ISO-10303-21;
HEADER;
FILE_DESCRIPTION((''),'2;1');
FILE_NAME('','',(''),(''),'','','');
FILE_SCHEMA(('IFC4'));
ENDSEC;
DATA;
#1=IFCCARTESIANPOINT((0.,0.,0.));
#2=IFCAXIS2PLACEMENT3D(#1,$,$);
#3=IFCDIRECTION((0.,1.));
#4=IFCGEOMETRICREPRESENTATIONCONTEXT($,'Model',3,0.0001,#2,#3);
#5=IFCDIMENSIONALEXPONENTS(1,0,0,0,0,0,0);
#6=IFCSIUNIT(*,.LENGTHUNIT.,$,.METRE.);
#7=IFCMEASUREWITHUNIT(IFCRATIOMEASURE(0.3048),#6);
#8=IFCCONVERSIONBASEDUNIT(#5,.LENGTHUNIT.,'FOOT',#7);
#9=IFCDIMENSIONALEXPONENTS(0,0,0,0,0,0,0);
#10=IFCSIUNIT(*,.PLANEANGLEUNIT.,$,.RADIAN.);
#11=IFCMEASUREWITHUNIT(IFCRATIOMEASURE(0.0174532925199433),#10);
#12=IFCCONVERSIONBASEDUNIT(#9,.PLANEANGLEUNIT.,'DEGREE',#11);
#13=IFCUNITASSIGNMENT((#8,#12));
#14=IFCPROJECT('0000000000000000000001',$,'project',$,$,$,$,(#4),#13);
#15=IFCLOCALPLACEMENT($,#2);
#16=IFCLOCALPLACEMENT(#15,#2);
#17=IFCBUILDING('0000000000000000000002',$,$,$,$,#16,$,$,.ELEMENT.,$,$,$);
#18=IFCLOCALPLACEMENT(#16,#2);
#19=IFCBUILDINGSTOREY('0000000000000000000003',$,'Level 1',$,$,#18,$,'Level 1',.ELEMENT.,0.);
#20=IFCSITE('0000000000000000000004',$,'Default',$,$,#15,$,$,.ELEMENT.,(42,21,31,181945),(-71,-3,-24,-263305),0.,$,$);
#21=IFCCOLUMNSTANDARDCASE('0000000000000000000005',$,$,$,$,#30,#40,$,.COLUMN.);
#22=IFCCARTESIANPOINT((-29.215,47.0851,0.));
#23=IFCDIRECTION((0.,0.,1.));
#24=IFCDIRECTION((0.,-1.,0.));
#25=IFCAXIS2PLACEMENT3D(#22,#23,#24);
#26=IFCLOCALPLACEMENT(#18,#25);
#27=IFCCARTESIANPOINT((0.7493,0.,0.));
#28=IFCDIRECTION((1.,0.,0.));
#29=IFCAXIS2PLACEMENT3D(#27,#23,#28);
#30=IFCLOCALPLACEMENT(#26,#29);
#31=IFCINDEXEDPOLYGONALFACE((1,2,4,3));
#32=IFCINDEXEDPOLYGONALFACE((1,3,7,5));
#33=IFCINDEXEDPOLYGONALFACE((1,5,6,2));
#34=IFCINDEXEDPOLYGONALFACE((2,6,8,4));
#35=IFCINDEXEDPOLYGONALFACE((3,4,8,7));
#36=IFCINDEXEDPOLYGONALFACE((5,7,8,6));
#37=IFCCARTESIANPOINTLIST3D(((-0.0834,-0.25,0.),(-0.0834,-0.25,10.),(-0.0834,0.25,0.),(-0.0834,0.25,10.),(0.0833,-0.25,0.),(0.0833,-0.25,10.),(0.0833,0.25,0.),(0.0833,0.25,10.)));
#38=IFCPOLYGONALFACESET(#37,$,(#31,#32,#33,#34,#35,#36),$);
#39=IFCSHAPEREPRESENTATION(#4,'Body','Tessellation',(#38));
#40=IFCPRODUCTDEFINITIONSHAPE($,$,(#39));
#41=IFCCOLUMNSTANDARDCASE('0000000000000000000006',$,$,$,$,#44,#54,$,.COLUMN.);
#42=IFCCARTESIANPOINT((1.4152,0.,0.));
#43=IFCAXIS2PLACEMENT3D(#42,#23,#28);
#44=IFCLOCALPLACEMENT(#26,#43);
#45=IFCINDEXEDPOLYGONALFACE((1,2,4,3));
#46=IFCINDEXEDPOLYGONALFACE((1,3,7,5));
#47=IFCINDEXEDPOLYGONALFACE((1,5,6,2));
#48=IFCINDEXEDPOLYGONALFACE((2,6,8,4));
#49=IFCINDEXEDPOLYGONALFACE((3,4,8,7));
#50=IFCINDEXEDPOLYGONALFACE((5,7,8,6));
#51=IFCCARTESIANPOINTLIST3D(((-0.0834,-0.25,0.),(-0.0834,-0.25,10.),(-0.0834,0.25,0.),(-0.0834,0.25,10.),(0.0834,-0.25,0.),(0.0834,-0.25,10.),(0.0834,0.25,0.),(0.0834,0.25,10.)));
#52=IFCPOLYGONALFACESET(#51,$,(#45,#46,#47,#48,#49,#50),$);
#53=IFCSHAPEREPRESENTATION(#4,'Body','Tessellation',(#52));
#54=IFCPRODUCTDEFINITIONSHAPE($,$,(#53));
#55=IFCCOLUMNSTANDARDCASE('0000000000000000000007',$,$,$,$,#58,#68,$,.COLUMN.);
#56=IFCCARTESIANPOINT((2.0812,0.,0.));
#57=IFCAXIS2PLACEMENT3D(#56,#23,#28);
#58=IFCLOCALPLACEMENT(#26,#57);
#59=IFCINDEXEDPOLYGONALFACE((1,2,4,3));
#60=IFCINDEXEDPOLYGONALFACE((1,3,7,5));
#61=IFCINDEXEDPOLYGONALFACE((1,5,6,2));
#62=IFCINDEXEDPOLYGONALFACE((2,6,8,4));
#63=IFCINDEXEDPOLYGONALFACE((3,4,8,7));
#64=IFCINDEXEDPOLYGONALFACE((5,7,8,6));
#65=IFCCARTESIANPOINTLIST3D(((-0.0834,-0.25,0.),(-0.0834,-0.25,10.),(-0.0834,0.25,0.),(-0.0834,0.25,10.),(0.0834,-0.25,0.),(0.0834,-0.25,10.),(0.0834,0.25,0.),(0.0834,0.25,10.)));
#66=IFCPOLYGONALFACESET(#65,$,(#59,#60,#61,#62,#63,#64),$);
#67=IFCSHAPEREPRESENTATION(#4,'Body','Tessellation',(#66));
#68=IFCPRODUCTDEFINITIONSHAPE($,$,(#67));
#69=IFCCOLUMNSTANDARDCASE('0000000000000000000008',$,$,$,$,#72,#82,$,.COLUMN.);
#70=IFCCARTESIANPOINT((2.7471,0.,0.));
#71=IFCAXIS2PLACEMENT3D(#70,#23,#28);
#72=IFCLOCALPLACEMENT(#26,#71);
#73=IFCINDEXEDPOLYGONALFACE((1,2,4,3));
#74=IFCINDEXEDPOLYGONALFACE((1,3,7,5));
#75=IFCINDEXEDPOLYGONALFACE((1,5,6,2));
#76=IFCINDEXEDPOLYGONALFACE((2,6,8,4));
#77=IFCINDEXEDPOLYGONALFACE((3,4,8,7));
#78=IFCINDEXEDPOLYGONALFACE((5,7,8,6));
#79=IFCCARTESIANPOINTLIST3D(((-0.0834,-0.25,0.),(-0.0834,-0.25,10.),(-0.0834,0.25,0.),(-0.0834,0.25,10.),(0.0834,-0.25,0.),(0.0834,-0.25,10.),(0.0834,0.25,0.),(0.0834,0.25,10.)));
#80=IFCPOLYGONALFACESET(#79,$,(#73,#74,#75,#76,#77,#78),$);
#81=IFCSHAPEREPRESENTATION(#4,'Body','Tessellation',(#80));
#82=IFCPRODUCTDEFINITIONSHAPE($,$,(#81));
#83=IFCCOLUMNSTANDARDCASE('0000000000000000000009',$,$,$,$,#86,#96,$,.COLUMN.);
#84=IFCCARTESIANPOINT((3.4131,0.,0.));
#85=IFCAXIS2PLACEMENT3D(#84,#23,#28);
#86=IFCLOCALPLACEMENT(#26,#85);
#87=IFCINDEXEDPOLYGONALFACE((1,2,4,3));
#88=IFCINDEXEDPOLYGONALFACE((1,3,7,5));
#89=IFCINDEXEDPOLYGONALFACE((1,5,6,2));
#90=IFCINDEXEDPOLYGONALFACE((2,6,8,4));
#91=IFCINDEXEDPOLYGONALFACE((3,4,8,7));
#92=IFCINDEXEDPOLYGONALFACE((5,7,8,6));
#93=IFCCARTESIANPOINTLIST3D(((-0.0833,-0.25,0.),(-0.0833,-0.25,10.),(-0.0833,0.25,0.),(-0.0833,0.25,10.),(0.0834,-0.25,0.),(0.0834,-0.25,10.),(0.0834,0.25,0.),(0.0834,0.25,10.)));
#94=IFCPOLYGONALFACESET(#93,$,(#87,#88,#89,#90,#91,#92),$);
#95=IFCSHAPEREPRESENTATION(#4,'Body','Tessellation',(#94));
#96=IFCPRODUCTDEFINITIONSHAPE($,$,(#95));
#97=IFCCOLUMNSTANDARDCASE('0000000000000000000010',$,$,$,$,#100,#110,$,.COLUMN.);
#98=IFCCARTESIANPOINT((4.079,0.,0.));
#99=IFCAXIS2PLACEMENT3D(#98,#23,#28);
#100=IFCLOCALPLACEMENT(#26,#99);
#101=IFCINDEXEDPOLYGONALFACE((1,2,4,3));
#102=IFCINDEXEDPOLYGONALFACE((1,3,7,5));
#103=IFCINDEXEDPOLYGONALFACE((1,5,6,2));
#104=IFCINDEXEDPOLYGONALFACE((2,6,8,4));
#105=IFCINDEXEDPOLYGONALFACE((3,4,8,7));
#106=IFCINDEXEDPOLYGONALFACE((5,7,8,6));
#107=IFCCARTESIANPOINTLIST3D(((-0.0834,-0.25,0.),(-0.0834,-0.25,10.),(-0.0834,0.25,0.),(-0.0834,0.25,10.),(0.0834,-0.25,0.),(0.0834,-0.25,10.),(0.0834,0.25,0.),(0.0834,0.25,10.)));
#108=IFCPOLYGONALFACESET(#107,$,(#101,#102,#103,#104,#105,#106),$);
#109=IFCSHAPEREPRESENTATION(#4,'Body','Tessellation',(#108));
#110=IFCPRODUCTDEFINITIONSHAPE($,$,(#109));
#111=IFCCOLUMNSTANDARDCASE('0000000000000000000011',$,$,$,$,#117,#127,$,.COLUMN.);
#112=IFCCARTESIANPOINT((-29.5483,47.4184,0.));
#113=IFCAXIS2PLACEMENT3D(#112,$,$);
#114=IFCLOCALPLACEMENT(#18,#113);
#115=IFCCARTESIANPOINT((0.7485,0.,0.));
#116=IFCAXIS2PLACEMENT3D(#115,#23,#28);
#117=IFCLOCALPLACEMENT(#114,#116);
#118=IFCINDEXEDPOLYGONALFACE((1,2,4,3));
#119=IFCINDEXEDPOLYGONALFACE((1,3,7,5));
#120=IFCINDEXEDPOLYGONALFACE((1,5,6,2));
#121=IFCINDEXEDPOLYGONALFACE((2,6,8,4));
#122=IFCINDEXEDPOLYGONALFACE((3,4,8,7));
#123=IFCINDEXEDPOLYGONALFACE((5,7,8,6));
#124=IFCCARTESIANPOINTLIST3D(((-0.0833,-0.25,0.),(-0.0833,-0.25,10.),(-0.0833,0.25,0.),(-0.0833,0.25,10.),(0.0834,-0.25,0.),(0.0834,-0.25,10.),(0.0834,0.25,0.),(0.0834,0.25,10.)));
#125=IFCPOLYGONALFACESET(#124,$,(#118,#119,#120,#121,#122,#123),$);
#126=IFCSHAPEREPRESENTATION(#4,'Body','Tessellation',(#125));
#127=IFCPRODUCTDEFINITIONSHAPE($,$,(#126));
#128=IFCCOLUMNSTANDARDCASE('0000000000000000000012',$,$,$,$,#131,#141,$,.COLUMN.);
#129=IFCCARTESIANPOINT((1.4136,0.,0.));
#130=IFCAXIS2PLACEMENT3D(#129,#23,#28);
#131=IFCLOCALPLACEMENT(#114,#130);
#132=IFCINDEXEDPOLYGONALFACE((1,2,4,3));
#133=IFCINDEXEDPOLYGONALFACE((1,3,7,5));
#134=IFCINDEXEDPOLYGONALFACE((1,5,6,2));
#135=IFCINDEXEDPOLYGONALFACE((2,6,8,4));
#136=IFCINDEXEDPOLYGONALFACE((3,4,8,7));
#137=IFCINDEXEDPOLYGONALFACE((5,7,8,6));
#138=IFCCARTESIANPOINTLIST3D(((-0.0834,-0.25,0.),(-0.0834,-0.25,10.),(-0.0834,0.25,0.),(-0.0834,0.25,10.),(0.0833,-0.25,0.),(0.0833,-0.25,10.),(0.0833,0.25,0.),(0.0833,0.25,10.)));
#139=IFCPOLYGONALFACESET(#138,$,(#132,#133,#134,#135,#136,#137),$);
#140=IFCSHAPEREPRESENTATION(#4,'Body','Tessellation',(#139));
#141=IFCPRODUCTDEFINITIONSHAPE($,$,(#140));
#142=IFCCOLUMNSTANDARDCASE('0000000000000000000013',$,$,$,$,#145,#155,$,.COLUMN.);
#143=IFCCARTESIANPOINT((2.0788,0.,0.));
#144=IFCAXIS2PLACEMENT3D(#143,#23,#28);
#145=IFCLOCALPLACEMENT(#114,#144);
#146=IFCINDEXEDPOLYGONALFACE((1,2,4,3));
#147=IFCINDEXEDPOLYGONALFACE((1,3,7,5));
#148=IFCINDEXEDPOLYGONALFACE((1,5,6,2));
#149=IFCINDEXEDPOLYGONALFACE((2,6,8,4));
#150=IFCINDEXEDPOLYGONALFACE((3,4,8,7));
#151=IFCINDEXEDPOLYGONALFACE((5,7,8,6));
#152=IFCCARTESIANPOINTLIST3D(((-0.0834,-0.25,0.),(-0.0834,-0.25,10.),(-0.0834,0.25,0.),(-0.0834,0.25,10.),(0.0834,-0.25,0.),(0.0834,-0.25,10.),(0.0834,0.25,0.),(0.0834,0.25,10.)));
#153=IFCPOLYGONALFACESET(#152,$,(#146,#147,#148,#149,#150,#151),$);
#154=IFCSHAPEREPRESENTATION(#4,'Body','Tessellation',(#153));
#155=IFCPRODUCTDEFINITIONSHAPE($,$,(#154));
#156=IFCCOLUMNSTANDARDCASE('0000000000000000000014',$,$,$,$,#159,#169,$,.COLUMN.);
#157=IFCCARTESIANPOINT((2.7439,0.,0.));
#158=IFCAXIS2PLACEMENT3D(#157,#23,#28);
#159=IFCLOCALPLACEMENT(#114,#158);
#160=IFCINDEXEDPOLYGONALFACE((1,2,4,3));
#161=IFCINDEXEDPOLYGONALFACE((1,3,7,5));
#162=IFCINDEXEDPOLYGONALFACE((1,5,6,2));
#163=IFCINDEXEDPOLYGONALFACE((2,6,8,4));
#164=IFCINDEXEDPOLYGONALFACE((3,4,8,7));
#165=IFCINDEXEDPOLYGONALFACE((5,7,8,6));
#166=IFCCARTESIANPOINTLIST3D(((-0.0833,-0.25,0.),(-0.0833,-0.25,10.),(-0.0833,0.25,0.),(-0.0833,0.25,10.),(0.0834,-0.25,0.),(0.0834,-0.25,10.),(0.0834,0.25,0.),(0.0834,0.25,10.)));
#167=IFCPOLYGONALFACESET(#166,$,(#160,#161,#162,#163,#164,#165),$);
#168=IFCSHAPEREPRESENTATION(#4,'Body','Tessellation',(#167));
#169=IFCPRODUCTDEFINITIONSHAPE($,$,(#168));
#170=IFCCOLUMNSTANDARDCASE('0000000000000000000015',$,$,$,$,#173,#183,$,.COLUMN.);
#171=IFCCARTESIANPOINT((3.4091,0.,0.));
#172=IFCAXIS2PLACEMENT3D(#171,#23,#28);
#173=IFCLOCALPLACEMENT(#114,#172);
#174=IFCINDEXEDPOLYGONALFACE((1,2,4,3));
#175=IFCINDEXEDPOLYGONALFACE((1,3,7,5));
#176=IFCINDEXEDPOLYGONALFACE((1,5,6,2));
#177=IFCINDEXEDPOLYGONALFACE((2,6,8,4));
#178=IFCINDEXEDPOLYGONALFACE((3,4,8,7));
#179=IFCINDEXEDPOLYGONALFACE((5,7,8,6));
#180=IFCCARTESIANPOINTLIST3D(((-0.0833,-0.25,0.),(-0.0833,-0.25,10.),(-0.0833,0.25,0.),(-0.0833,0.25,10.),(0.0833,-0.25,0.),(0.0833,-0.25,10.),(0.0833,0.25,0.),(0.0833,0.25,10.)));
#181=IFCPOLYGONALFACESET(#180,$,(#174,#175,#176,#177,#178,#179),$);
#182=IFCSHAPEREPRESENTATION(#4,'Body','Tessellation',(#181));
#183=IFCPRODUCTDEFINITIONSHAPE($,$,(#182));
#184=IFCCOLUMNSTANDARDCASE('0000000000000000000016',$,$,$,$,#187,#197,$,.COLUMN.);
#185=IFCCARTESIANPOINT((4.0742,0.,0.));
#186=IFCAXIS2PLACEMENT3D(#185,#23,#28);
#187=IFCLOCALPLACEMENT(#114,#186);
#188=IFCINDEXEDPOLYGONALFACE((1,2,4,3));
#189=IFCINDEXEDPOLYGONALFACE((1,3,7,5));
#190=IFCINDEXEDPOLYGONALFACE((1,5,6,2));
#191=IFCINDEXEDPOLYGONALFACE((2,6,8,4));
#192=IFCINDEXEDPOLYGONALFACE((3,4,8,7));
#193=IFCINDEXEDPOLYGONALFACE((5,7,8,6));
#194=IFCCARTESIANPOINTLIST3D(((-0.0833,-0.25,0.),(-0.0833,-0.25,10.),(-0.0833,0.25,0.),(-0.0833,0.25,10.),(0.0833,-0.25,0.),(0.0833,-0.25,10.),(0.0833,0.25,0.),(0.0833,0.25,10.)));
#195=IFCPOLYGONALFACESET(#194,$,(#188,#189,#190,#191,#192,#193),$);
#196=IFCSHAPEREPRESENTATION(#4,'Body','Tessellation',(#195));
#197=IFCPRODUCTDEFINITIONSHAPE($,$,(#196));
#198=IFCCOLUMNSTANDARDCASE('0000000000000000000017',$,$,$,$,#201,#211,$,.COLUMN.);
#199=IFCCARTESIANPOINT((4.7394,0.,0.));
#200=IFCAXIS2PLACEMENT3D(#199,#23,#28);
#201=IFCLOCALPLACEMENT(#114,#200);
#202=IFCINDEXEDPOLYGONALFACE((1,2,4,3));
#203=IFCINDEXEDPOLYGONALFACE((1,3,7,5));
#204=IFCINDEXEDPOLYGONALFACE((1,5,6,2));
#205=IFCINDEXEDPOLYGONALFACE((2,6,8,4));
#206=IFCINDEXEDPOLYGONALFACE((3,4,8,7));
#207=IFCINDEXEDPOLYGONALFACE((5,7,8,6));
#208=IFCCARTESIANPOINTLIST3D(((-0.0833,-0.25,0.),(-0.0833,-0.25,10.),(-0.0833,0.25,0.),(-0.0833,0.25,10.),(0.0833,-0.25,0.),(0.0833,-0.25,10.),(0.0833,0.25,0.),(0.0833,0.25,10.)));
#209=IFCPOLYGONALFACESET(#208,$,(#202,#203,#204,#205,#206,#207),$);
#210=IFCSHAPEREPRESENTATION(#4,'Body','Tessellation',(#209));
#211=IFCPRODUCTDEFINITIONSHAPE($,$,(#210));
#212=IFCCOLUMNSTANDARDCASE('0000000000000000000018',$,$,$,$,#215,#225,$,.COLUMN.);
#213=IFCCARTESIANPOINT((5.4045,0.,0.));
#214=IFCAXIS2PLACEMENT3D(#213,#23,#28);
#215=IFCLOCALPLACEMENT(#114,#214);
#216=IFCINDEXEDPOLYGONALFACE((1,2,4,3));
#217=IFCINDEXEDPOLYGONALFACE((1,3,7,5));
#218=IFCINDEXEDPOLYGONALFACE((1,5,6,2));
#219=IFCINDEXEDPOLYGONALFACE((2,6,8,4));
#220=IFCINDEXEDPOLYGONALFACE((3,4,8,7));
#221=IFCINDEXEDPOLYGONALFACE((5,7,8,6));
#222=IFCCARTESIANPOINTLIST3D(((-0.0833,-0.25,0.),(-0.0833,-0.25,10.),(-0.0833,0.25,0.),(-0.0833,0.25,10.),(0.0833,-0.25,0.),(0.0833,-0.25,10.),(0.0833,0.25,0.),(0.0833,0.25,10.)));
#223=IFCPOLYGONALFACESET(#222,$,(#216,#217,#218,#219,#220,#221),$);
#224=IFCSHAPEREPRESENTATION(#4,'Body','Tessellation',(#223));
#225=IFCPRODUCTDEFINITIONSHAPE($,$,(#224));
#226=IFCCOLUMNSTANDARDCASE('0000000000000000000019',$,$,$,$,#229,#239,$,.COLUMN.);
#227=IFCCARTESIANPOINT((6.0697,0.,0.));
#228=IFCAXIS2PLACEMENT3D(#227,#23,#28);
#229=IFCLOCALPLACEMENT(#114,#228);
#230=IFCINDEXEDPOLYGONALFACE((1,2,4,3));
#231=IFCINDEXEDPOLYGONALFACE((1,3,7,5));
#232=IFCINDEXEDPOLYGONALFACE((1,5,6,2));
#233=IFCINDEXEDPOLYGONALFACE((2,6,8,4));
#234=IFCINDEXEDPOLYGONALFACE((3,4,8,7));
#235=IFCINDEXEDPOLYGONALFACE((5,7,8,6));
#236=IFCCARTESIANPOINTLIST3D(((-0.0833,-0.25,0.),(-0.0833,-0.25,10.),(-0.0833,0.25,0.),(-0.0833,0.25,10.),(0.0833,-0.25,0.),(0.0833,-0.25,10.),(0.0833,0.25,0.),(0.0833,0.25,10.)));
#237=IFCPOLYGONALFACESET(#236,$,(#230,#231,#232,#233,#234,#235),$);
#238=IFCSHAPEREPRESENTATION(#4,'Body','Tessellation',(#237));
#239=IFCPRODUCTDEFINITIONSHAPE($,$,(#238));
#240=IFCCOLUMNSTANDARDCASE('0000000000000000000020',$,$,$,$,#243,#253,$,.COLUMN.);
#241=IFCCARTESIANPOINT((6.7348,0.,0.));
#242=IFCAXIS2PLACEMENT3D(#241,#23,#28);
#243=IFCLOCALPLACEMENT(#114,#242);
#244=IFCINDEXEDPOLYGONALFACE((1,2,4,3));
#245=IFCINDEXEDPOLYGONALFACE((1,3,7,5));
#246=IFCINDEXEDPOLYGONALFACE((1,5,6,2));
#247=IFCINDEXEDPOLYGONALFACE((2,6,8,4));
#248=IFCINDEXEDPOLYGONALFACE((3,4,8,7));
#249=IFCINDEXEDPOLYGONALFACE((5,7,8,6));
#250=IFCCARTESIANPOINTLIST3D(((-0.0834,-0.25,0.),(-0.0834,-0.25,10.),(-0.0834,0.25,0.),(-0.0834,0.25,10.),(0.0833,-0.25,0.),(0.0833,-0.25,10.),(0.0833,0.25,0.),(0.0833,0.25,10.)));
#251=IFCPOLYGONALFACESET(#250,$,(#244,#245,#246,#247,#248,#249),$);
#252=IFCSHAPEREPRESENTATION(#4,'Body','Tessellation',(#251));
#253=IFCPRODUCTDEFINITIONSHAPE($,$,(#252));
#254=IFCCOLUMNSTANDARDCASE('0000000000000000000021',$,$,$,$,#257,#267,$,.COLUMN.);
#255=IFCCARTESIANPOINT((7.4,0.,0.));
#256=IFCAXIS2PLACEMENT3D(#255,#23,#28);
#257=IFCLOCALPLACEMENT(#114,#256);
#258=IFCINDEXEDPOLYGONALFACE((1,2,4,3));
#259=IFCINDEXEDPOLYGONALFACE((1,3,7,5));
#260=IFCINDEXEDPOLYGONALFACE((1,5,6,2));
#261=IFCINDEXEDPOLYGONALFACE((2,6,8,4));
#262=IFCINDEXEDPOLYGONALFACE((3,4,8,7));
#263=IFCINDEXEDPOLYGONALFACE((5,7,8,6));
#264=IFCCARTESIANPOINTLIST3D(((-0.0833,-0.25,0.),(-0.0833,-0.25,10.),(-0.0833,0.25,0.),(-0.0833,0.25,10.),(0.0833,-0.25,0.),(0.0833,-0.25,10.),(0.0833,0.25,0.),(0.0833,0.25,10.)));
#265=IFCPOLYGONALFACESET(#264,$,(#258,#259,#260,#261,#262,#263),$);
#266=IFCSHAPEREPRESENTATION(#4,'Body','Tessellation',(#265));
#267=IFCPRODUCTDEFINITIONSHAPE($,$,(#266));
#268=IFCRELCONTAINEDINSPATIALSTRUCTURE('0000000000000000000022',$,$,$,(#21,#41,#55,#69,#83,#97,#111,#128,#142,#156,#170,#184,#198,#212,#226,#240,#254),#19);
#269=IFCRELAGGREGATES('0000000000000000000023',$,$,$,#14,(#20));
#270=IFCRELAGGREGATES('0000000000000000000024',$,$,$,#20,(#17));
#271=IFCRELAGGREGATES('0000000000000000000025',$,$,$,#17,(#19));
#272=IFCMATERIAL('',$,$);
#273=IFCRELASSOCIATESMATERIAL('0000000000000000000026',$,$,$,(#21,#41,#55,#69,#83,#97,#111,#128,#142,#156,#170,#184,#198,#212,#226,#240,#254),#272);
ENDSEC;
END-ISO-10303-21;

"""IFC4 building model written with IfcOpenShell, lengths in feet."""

from ifc_helpers import new_model, entity, si_unit, converted_unit, direction, frame, origin, place, context, project, spatial, rectangle, extrude, material, element, save


model = new_model("IFC4")

# Units and contexts
model_context = context("Model", 3, precision=0.0001, world=origin(), true_north=direction((0.0, 1.0)))
ifc_project = project(units=[converted_unit("LENGTHUNIT", "FOOT", entity("IfcRatioMeasure", 0.3048), si_unit("LENGTHUNIT", "METRE"), dimensions=[1, 0, 0, 0, 0, 0, 0]), converted_unit("PLANEANGLEUNIT", "DEGREE", entity("IfcRatioMeasure", 0.0174532925199433), si_unit("PLANEANGLEUNIT", "RADIAN"), dimensions=[0, 0, 0, 0, 0, 0, 0])], contexts=[model_context])

# Site, building, storey
site_placement = place(None, origin())
site = spatial("IfcSite", under=ifc_project, at=site_placement, Name="Default", CompositionType="ELEMENT", RefLatitude=(42, 21, 31, 181945), RefLongitude=(-71, -3, -24, -263305), RefElevation=0.0)
building_placement = place(site_placement, origin())
building = spatial("IfcBuilding", under=site, at=building_placement, CompositionType="ELEMENT")
storey_placement = place(building_placement, origin())
storey = spatial("IfcBuildingStorey", under=building, at=storey_placement, Name="Level 1", LongName="Level 1", CompositionType="ELEMENT", Elevation=0.0)

# Columns
ifc_material_1 = material(Name="")
wall_1_placement = place(storey_placement, frame((-29.215, 47.0851, 0.0), z_axis=(0.0, 0.0, 1.0), x_axis=(0.0, -1.0, 0.0)))
for number, where, z_axis, x_axis in (
    (1, (0.7493, 0.0, 0.0), (0.0, 0.0, 1.0), (1.0, 0.0, 0.0)),
    (2, (1.4152, 0.0, 0.0), (0.0, 0.0, 1.0), (1.0, 0.0, 0.0)),
    (3, (2.0812, 0.0, 0.0), (0.0, 0.0, 1.0), (1.0, 0.0, 0.0)),
    (4, (2.7471, 0.0, 0.0), (0.0, 0.0, 1.0), (1.0, 0.0, 0.0)),
    (5, (3.4131, 0.0, 0.0), (0.0, 0.0, 1.0), (1.0, 0.0, 0.0)),
    (6, (4.079, 0.0, 0.0), (0.0, 0.0, 1.0), (1.0, 0.0, 0.0)),
):
    element("IfcColumnStandardCase", number, at=place(wall_1_placement, frame(where, z_axis=z_axis, x_axis=x_axis)), inside=storey, material=ifc_material_1, PredefinedType="COLUMN", context=model_context, shape_type="SweptSolid", body=[
        extrude(rectangle(XDim=0.1667, YDim=0.5), origin(), (0.0, 0.0, 1.0), 10.0),
    ])
wall_2_placement = place(storey_placement, frame((-29.5483, 47.4184, 0.0)))
for number, where, z_axis, x_axis in (
    (7, (0.7485, 0.0, 0.0), (0.0, 0.0, 1.0), (1.0, 0.0, 0.0)),
    (8, (1.4136, 0.0, 0.0), (0.0, 0.0, 1.0), (1.0, 0.0, 0.0)),
    (9, (2.0788, 0.0, 0.0), (0.0, 0.0, 1.0), (1.0, 0.0, 0.0)),
    (10, (2.7439, 0.0, 0.0), (0.0, 0.0, 1.0), (1.0, 0.0, 0.0)),
    (11, (3.4091, 0.0, 0.0), (0.0, 0.0, 1.0), (1.0, 0.0, 0.0)),
    (12, (4.0742, 0.0, 0.0), (0.0, 0.0, 1.0), (1.0, 0.0, 0.0)),
    (13, (4.7394, 0.0, 0.0), (0.0, 0.0, 1.0), (1.0, 0.0, 0.0)),
    (14, (5.4045, 0.0, 0.0), (0.0, 0.0, 1.0), (1.0, 0.0, 0.0)),
    (15, (6.0697, 0.0, 0.0), (0.0, 0.0, 1.0), (1.0, 0.0, 0.0)),
    (16, (6.7348, 0.0, 0.0), (0.0, 0.0, 1.0), (1.0, 0.0, 0.0)),
    (17, (7.4, 0.0, 0.0), (0.0, 0.0, 1.0), (1.0, 0.0, 0.0)),
):
    element("IfcColumnStandardCase", number, at=place(wall_2_placement, frame(where, z_axis=z_axis, x_axis=x_axis)), inside=storey, material=ifc_material_1, PredefinedType="COLUMN", context=model_context, shape_type="SweptSolid", body=[
        extrude(rectangle(XDim=0.1667, YDim=0.5), origin(), (0.0, 0.0, 1.0), 10.0),
    ])

save(model, "model.ifc")
